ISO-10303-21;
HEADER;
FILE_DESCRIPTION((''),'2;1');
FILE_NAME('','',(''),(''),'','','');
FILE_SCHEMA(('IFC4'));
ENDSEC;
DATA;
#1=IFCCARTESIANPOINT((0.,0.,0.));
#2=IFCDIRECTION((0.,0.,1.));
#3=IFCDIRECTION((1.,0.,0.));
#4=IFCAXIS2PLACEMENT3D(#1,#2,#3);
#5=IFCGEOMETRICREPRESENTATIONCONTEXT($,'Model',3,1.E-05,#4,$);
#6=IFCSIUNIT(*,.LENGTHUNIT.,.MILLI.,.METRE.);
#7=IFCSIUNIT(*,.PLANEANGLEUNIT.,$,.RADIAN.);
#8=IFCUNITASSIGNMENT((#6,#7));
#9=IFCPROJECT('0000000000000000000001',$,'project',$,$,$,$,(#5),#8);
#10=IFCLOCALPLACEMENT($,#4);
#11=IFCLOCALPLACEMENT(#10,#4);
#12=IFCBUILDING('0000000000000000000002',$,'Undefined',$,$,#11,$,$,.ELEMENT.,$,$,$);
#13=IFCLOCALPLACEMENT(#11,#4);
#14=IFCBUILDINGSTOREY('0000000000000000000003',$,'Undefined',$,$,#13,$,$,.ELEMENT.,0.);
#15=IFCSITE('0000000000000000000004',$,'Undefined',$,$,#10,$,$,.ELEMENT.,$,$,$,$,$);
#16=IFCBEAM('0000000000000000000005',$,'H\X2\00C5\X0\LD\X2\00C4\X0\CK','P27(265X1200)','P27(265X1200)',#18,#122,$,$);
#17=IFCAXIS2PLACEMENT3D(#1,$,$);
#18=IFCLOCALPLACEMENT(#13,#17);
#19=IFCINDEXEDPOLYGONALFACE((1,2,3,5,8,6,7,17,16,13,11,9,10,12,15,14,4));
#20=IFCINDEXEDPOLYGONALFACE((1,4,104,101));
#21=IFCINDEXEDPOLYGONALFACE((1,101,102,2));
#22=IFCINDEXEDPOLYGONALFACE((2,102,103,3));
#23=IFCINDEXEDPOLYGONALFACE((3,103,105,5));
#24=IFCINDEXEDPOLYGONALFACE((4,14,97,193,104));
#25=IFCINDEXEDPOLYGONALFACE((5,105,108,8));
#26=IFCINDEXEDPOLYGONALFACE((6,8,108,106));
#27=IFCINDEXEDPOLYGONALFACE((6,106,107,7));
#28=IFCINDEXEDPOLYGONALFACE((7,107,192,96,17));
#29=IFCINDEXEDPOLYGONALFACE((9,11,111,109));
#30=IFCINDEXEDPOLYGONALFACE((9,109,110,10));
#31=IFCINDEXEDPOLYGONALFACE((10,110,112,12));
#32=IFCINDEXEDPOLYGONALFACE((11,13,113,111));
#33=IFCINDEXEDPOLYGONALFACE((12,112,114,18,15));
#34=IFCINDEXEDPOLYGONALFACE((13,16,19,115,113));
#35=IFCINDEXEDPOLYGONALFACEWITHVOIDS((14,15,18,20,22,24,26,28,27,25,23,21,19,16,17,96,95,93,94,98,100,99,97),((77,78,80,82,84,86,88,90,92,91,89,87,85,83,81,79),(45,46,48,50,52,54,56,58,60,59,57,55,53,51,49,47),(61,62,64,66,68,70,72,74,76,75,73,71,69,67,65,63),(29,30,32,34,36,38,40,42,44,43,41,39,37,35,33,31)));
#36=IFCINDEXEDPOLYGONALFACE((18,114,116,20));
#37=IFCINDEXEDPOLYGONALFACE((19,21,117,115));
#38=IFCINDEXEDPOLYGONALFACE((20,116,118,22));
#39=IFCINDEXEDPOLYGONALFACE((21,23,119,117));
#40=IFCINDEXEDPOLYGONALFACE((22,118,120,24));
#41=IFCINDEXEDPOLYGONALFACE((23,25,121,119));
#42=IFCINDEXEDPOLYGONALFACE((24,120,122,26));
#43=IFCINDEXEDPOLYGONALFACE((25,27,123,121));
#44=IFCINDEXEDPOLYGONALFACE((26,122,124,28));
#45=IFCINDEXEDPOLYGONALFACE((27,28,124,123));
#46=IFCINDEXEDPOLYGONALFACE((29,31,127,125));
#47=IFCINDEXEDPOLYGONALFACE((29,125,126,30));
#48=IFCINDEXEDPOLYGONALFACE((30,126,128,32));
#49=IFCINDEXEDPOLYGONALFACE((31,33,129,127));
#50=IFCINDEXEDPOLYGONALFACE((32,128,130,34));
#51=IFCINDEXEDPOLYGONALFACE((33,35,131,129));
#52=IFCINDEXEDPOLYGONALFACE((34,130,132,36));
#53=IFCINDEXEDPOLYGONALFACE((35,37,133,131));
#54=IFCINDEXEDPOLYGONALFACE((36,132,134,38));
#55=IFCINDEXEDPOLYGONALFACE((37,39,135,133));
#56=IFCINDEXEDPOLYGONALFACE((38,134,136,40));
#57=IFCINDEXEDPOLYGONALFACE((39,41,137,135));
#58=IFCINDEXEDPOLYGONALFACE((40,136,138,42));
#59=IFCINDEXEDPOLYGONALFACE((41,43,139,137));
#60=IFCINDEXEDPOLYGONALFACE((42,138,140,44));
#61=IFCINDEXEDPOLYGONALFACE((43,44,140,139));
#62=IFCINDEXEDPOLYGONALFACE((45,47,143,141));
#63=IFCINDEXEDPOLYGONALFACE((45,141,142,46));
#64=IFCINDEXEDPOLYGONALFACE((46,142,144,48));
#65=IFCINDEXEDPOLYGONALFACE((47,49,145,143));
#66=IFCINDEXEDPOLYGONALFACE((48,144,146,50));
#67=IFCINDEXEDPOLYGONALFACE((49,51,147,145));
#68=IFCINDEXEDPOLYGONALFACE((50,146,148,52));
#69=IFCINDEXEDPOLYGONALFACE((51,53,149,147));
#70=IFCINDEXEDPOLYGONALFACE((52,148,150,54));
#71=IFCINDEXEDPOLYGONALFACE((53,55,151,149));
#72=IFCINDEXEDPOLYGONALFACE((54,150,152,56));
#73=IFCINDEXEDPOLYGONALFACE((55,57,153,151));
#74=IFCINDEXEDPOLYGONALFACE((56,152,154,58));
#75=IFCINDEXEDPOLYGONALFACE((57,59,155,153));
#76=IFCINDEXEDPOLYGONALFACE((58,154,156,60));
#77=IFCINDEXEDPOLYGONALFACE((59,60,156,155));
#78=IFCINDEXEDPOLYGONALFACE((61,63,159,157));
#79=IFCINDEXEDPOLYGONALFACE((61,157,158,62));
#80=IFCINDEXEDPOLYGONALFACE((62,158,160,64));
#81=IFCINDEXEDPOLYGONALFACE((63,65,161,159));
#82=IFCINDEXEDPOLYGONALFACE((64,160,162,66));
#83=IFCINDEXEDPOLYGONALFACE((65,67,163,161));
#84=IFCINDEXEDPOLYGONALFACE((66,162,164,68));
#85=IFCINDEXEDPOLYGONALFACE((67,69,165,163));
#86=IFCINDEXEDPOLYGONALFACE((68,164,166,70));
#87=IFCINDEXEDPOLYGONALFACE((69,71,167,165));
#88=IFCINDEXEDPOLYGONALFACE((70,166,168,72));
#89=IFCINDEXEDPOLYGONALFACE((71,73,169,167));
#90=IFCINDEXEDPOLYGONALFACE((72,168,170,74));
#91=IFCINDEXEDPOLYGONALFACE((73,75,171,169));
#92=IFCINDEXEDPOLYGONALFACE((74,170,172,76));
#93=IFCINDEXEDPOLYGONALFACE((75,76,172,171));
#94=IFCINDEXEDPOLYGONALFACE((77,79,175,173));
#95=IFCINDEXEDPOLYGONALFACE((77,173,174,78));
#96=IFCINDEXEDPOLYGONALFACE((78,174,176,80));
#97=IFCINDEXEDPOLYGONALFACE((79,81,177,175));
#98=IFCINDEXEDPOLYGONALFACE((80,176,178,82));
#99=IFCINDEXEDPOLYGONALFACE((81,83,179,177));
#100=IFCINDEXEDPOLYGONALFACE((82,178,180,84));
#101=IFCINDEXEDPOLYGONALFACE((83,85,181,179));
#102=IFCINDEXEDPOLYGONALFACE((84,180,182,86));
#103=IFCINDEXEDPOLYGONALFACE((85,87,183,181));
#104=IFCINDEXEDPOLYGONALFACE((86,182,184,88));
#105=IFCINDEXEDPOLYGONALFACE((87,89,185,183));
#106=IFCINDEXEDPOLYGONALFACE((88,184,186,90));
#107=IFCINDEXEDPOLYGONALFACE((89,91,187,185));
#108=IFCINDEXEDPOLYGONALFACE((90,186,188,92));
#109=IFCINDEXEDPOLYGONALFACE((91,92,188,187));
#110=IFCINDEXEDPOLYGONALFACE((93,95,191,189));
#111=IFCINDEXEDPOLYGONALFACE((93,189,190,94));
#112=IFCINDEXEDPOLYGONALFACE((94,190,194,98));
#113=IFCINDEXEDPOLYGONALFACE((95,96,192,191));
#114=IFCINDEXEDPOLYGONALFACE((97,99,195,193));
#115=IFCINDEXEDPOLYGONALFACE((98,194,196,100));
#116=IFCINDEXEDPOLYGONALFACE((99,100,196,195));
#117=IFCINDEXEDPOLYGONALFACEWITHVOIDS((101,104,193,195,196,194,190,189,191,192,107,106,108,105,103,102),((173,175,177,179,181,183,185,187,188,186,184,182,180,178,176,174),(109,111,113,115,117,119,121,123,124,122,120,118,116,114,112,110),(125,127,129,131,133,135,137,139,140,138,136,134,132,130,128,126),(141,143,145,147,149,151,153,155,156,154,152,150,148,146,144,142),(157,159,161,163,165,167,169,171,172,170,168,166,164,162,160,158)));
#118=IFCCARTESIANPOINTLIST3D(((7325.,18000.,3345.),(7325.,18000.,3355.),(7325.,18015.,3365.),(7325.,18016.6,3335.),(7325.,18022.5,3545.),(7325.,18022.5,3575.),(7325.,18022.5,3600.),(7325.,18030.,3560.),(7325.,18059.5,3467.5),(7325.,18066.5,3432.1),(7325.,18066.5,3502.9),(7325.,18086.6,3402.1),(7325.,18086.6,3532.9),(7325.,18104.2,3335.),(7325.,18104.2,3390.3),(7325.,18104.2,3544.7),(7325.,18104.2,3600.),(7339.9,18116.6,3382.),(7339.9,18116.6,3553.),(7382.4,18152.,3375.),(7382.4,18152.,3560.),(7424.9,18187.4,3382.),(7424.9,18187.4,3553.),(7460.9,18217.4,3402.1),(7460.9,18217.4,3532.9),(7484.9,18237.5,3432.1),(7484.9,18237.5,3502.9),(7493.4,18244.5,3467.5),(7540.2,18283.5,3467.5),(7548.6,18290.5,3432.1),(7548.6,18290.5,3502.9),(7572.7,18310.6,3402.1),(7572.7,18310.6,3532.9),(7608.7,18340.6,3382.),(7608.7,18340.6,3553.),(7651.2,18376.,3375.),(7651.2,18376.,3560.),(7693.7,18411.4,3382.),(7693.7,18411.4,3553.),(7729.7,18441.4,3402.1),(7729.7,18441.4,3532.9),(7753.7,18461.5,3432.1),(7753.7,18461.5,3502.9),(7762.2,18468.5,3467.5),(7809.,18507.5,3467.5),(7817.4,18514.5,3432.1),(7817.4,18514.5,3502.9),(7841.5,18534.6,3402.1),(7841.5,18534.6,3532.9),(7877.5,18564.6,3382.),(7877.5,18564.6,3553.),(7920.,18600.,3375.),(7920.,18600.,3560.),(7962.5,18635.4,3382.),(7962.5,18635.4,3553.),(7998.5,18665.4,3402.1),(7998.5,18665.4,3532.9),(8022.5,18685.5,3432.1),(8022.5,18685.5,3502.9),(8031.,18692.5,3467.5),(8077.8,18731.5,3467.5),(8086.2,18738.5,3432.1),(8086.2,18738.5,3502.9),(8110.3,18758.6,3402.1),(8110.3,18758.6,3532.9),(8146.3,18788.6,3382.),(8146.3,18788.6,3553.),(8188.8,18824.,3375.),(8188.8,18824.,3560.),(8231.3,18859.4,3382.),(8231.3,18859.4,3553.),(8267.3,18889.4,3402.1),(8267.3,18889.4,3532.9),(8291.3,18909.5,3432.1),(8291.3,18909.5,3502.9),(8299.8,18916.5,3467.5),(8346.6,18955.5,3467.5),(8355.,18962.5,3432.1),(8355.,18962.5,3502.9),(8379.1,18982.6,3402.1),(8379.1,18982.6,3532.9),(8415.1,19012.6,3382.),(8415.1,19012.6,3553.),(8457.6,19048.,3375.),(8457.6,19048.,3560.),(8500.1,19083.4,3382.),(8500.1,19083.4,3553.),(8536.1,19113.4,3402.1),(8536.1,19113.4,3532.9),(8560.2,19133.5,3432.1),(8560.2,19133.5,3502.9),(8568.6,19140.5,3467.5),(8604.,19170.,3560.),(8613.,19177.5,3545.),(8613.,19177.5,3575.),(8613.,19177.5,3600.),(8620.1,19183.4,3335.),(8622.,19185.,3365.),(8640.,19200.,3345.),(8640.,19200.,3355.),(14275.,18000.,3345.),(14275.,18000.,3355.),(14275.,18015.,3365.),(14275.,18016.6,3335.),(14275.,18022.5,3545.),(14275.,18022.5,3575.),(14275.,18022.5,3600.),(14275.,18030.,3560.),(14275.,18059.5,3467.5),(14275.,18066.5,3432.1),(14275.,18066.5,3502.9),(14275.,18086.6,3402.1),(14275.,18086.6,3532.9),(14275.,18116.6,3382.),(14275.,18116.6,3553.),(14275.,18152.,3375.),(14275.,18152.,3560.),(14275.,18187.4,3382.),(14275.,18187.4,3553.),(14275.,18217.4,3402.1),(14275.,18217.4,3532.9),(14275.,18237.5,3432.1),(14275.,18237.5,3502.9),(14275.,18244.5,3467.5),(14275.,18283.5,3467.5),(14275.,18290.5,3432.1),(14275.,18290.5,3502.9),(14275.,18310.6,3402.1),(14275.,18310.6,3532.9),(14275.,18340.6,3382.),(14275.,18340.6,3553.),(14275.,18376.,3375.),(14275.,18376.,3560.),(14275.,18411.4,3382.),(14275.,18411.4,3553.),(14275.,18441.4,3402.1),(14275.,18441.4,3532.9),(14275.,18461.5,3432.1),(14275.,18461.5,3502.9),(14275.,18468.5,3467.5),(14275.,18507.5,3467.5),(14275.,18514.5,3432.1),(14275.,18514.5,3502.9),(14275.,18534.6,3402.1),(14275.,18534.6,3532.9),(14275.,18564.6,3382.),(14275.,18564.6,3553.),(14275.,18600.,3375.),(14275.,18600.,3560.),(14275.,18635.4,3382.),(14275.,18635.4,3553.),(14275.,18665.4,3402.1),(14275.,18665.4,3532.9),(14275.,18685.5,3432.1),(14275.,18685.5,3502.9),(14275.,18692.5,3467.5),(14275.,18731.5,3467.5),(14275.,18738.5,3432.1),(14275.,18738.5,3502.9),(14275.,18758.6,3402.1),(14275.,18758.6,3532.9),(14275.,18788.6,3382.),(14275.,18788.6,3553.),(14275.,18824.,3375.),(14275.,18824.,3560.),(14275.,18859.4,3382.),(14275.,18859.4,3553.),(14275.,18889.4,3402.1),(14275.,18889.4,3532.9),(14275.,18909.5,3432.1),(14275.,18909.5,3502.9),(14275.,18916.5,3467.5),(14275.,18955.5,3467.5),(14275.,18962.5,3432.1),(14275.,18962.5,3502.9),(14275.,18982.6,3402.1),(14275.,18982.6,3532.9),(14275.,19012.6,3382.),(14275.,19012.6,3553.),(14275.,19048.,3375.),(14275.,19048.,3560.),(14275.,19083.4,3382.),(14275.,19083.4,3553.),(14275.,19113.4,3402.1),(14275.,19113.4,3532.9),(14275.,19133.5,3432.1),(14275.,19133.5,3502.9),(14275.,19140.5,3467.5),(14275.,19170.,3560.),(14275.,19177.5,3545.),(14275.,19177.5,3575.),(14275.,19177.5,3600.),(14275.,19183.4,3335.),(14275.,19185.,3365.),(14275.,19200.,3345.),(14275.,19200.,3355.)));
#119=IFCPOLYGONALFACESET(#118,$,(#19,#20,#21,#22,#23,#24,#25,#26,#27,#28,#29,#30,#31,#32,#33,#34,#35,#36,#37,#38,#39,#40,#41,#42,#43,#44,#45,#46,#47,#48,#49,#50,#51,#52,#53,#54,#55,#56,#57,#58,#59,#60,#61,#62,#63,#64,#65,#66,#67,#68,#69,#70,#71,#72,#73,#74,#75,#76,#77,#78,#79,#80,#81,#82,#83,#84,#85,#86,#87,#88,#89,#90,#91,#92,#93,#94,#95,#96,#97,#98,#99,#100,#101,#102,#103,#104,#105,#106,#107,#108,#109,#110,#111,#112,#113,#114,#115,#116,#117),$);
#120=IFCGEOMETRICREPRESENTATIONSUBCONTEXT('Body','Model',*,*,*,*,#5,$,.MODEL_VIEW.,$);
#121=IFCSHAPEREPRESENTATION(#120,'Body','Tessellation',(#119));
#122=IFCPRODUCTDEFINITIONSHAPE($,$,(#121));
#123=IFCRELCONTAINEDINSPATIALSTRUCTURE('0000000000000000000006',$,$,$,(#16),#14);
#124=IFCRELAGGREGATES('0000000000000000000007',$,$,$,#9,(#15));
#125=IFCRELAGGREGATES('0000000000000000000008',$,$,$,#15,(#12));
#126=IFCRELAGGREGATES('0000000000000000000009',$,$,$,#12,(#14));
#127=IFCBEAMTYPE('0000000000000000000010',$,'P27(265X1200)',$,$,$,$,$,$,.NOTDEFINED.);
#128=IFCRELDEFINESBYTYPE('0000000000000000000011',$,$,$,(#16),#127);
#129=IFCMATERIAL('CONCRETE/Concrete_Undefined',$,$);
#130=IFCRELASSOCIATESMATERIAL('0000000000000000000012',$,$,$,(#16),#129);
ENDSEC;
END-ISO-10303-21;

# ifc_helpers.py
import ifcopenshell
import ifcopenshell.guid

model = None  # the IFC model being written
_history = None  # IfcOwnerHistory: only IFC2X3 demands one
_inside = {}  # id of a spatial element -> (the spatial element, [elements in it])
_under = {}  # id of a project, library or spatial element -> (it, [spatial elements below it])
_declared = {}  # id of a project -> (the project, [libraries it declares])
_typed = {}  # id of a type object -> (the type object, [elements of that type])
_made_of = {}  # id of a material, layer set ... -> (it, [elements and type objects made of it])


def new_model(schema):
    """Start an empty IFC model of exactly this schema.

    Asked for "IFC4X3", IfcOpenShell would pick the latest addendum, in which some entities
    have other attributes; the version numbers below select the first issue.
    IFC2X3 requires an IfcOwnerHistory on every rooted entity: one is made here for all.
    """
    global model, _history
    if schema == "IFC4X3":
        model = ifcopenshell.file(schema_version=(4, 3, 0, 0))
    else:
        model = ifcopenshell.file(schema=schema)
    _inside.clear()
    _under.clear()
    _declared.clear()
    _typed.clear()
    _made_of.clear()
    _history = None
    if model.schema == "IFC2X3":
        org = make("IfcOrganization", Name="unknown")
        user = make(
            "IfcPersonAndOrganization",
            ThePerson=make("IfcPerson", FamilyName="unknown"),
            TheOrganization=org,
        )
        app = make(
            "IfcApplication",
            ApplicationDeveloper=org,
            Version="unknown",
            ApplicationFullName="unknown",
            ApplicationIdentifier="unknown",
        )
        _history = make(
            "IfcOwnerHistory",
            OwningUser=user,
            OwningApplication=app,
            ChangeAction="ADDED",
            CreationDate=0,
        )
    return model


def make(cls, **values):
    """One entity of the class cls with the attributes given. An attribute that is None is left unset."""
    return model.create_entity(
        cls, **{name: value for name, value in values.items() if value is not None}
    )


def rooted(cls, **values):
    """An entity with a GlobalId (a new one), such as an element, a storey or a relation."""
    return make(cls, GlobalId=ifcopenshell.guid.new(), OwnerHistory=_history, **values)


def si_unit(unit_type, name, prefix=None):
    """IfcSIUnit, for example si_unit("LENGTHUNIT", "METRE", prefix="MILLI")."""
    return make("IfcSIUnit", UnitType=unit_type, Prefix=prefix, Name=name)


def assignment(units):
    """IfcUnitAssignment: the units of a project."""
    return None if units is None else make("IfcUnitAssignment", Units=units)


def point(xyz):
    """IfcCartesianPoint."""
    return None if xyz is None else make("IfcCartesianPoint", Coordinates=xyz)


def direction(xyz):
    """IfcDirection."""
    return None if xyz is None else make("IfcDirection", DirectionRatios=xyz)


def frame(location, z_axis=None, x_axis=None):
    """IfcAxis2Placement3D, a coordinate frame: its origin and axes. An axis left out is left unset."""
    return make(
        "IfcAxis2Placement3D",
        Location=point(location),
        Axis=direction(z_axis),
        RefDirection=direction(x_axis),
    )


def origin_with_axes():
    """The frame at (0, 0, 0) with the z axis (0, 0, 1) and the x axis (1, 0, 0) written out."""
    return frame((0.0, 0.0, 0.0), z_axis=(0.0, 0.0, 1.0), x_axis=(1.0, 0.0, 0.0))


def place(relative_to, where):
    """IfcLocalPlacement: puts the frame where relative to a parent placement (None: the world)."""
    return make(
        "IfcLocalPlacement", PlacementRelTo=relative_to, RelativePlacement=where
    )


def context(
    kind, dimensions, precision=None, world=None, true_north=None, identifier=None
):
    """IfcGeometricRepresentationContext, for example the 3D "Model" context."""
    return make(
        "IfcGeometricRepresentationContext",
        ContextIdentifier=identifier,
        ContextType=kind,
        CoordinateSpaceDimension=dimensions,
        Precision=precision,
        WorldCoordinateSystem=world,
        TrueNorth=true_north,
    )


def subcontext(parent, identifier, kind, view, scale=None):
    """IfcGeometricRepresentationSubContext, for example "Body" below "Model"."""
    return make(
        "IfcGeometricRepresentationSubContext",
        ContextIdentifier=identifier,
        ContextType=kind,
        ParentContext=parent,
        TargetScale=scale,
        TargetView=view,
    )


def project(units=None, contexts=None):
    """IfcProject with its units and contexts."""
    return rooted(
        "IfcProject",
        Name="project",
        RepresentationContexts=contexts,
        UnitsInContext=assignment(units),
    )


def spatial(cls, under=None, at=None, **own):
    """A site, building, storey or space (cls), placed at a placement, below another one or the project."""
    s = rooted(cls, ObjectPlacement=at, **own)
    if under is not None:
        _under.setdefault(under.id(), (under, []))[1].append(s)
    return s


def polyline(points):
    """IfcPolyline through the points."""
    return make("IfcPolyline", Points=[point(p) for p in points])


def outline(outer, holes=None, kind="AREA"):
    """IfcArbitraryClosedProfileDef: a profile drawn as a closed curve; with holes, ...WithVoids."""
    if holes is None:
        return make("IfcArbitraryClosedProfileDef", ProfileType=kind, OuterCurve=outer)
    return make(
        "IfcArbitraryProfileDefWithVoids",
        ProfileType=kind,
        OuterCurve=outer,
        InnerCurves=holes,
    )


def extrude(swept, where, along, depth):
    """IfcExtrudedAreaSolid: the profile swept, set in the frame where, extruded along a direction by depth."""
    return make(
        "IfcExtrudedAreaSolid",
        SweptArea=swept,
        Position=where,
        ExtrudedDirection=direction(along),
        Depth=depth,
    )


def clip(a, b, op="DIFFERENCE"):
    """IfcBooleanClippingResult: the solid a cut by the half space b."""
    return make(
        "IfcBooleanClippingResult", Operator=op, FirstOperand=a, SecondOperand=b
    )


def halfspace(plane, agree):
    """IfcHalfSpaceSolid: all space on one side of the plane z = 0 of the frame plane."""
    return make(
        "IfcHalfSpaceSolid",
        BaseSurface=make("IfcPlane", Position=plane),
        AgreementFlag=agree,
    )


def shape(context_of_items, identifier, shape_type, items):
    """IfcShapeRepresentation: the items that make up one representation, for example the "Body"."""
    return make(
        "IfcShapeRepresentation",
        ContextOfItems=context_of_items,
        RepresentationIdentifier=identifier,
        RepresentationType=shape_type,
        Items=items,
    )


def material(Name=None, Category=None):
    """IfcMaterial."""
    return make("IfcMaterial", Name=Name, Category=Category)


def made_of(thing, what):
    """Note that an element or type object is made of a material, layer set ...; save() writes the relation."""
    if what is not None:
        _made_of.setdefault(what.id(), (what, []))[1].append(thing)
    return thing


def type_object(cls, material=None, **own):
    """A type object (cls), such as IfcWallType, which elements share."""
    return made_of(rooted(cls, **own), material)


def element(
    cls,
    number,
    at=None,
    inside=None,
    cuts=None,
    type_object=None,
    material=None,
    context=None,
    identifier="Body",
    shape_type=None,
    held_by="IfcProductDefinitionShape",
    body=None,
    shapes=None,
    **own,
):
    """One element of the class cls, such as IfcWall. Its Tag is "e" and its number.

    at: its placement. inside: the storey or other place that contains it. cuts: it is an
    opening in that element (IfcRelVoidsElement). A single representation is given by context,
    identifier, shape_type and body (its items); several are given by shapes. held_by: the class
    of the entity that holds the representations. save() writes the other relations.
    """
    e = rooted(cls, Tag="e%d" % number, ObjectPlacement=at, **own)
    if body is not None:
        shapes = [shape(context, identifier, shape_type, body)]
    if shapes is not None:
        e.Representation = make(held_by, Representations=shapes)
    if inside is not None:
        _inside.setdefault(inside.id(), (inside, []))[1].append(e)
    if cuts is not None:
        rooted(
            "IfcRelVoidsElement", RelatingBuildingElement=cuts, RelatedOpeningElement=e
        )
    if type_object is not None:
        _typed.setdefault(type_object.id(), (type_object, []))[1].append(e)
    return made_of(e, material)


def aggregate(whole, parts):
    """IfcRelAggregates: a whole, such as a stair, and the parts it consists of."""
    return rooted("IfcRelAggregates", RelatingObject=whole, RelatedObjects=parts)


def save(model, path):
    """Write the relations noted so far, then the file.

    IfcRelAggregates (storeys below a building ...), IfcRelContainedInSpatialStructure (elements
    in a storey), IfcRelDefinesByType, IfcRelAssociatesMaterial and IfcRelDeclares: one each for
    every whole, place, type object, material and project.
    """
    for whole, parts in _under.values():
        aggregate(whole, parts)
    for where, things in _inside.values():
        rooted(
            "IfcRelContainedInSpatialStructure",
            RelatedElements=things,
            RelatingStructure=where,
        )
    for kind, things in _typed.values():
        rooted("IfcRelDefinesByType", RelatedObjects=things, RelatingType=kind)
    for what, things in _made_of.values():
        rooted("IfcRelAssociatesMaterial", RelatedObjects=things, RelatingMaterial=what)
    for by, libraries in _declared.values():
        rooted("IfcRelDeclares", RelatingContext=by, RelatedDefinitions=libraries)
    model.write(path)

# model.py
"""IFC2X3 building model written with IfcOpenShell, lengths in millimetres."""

from ifc_helpers import new_model, si_unit, frame, origin_with_axes, place, context, subcontext, project, spatial, polyline, outline, extrude, clip, halfspace, material, type_object, element, save


model = new_model("IFC2X3")

# Units and contexts
model_context = context("Model", 3, precision=1e-05, world=origin_with_axes())
body_context = subcontext(model_context, "Body", "Model", "MODEL_VIEW")
ifc_project = project(units=[si_unit("LENGTHUNIT", "METRE", prefix="MILLI"), si_unit("PLANEANGLEUNIT", "RADIAN")], contexts=[model_context])

# Site, building, storey
site_placement = place(None, origin_with_axes())
site = spatial("IfcSite", under=ifc_project, at=site_placement, Name="Undefined", CompositionType="ELEMENT")
building_placement = place(site_placement, origin_with_axes())
building = spatial("IfcBuilding", under=site, at=building_placement, Name="Undefined", CompositionType="ELEMENT")
storey_placement = place(building_placement, origin_with_axes())
storey = spatial("IfcBuildingStorey", under=building, at=storey_placement, Name="Undefined", CompositionType="ELEMENT", Elevation=0.0)

# Beam
ifc_material_1 = material(Name="CONCRETE/Concrete_Undefined")
beam_type_1 = type_object("IfcBeamType", Name="P27(265X1200)", PredefinedType="NOTDEFINED")
beam_1_placement = place(storey_placement, frame((7325.0, 18600.0, 3467.5), z_axis=(0.0, 0.0, 1.0), x_axis=(1.0, 0.0, 0.0)))
element("IfcBeam", 1, at=beam_1_placement, inside=storey, type_object=beam_type_1, material=ifc_material_1, Name="HÅLDÄCK", Description="P27(265X1200)", ObjectType="P27(265X1200)", context=body_context, shape_type="Clipping", body=[
    clip(extrude(outline(polyline([(-583.4, -132.5), (-600.0, -122.5), (-600.0, -112.5), (-585.0, -102.5), (-577.5, 77.5), (-570.0, 92.5), (-577.5, 107.5), (-577.5, 132.5), (577.5, 132.5), (577.5, 107.5), (570.0, 92.5), (577.5, 77.5), (585.0, -102.5), (600.0, -112.5), (600.0, -122.5), (583.4, -132.5), (-583.4, -132.5)]), holes=[polyline([(-513.4, 65.4), (-533.5, 35.4), (-540.5, 0.0), (-533.5, -35.4), (-513.4, -65.4), (-483.4, -85.5), (-448.0, -92.5), (-412.6, -85.5), (-382.6, -65.4), (-362.5, -35.4), (-355.5, 0.0), (-362.5, 35.4), (-382.6, 65.4), (-412.6, 85.5), (-448.0, 92.5), (-483.4, 85.5), (-513.4, 65.4)]), polyline([(-289.4, 65.4), (-309.5, 35.4), (-316.5, 0.0), (-309.5, -35.4), (-289.4, -65.4), (-259.4, -85.5), (-224.0, -92.5), (-188.6, -85.5), (-158.6, -65.4), (-138.5, -35.4), (-131.5, 0.0), (-138.5, 35.4), (-158.6, 65.4), (-188.6, 85.5), (-224.0, 92.5), (-259.4, 85.5), (-289.4, 65.4)]), polyline([(-65.4, 65.4), (-85.5, 35.4), (-92.5, 0.0), (-85.5, -35.4), (-65.4, -65.4), (-35.4, -85.5), (0.0, -92.5), (35.4, -85.5), (65.4, -65.4), (85.5, -35.4), (92.5, 0.0), (85.5, 35.4), (65.4, 65.4), (35.4, 85.5), (0.0, 92.5), (-35.4, 85.5), (-65.4, 65.4)]), polyline([(158.6, 65.4), (138.5, 35.4), (131.5, 0.0), (138.5, -35.4), (158.6, -65.4), (188.6, -85.5), (224.0, -92.5), (259.4, -85.5), (289.4, -65.4), (309.5, -35.4), (316.5, 0.0), (309.5, 35.4), (289.4, 65.4), (259.4, 85.5), (224.0, 92.5), (188.6, 85.5), (158.6, 65.4)]), polyline([(382.6, 65.4), (362.5, 35.4), (355.5, 0.0), (362.5, -35.4), (382.6, -65.4), (412.6, -85.5), (448.0, -92.5), (483.4, -85.5), (513.4, -65.4), (533.5, -35.4), (540.5, 0.0), (533.5, 35.4), (513.4, 65.4), (483.4, 85.5), (448.0, 92.5), (412.6, 85.5), (382.6, 65.4)])]), frame((6950.0, 0.0, 0.0), z_axis=(-1.0, 0.0, 0.0), x_axis=(0.0, -1.0, 0.0)), (0.0, 0.0, 1.0), 6950.0), halfspace(frame((1315.0, 600.0, -132.5), z_axis=(-0.640183, 0.768222, 0.0), x_axis=(0.0, 0.0, 1.0)), False)),
])

save(model, "model.ifc")
